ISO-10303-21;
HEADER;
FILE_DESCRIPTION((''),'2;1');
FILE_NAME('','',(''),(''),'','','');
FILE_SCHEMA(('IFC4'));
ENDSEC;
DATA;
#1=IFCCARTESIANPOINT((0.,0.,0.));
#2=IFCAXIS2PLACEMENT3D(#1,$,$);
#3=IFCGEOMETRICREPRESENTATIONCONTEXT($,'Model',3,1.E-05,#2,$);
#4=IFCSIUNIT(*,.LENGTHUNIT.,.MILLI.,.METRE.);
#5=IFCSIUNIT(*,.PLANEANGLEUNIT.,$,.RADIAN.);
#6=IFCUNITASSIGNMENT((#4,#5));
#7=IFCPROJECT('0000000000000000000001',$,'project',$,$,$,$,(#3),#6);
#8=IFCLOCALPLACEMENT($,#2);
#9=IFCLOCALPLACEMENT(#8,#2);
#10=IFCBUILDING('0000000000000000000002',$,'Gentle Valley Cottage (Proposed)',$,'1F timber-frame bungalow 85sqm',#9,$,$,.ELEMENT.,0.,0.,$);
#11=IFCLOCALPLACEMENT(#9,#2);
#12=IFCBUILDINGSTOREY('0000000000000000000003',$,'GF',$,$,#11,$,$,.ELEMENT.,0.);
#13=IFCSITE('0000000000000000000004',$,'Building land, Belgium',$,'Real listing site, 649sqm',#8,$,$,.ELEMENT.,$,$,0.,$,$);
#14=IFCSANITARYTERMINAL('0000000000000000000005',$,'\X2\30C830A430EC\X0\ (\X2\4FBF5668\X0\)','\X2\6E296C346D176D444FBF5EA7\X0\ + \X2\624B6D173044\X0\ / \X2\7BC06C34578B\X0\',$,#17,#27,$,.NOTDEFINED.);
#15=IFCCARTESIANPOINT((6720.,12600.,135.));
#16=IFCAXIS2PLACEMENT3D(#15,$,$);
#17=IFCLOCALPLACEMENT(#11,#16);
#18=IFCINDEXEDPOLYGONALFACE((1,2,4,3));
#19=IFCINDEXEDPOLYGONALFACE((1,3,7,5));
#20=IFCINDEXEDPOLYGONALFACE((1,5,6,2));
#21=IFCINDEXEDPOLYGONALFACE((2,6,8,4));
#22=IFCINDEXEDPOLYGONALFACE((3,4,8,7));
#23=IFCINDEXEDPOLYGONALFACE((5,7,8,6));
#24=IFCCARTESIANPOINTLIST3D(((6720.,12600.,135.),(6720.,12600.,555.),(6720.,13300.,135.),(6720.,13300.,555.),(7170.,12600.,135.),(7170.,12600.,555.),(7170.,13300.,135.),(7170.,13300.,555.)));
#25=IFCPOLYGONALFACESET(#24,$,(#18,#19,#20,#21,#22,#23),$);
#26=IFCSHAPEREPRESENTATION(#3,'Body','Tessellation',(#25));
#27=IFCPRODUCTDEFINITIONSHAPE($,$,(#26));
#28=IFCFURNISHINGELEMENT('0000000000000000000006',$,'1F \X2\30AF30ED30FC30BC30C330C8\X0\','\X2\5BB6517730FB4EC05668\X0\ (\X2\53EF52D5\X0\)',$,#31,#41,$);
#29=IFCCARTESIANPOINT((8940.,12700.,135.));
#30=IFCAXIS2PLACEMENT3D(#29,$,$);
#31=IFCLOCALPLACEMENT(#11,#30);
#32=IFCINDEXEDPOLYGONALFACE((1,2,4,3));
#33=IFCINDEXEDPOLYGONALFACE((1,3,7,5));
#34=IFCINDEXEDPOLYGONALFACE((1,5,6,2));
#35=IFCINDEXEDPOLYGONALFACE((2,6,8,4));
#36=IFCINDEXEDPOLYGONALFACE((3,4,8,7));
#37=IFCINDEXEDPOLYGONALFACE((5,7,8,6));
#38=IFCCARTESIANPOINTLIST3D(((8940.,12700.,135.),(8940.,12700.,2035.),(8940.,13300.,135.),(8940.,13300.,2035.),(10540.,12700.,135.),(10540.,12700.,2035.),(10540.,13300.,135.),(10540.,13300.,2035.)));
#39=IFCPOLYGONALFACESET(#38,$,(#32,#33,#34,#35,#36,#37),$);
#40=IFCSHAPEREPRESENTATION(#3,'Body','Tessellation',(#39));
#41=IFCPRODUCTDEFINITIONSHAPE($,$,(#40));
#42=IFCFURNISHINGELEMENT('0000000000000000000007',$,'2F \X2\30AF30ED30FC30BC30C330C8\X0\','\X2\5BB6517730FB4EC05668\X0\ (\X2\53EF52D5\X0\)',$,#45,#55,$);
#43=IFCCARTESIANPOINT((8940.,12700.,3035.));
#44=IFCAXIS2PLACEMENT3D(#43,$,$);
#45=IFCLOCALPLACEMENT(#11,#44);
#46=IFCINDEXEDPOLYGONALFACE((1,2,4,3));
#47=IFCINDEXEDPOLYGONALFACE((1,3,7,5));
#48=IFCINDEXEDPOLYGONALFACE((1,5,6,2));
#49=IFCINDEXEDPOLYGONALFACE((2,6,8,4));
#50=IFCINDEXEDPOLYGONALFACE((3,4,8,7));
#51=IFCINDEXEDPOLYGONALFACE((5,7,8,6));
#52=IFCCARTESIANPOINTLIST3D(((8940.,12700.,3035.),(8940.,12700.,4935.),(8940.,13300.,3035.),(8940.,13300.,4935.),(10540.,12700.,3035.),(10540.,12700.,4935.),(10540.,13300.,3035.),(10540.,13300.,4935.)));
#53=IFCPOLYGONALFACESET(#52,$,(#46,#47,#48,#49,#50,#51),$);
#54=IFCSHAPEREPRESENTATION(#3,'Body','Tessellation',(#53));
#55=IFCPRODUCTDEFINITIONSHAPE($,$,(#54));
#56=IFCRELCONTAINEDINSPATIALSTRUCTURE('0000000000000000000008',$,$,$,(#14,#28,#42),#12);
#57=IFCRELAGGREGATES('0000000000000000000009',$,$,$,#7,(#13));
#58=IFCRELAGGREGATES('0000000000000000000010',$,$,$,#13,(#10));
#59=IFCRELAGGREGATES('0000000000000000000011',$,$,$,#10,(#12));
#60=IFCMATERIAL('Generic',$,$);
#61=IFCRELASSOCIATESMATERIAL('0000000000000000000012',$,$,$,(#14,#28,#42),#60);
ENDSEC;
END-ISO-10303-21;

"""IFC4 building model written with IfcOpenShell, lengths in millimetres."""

from ifc_helpers import new_model, si_unit, frame, frame_2d, origin, place, context, project, spatial, rectangle, extrude, material, element, save


model = new_model("IFC4")

# Units and contexts
model_context = context("Model", 3, precision=1e-05, world=origin())
ifc_project = project(units=[si_unit("LENGTHUNIT", "METRE", prefix="MILLI"), si_unit("PLANEANGLEUNIT", "RADIAN")], contexts=[model_context])

# Site, building, storey
site_placement = place(None, origin())
site = spatial("IfcSite", under=ifc_project, at=site_placement, Name="Building land, Belgium", ObjectType="Real listing site, 649sqm", CompositionType="ELEMENT", RefElevation=0.0)
building_placement = place(site_placement, origin())
building = spatial("IfcBuilding", under=site, at=building_placement, Name="Gentle Valley Cottage (Proposed)", ObjectType="1F timber-frame bungalow 85sqm", CompositionType="ELEMENT", ElevationOfRefHeight=0.0, ElevationOfTerrain=0.0)
storey_placement = place(building_placement, origin())
storey = spatial("IfcBuildingStorey", under=building, at=storey_placement, Name="GF", CompositionType="ELEMENT", Elevation=0.0)

# Sanitary terminal
ifc_material_1 = material(Name="Generic")
sanitary_terminal_1_placement = place(storey_placement, frame((6720.0, 12600.0, 135.0)))
element("IfcSanitaryTerminal", 1, at=sanitary_terminal_1_placement, inside=storey, material=ifc_material_1, Name="トイレ (便器)", Description="温水洗浄便座 + 手洗い / 節水型", PredefinedType="NOTDEFINED", context=model_context, shape_type="SweptSolid", body=[
    extrude(rectangle(XDim=450.0, YDim=700.0, at=frame_2d((225.0, 350.0))), frame((6720.0, 12600.0, 135.0)), (0.0, 0.0, 1.0), 420.0),
])

# Furnishing elements
furnishing_1_placement = place(storey_placement, frame((8940.0, 12700.0, 135.0)))
element("IfcFurnishingElement", 2, at=furnishing_1_placement, inside=storey, material=ifc_material_1, Name="1F クローゼット", Description="家具・什器 (可動)", context=model_context, shape_type="SweptSolid", body=[
    extrude(rectangle(XDim=1600.0, YDim=600.0, at=frame_2d((800.0, 300.0))), frame((8940.0, 12700.0, 135.0)), (0.0, 0.0, 1.0), 1900.0),
])
furnishing_2_placement = place(storey_placement, frame((8940.0, 12700.0, 3035.0)))
element("IfcFurnishingElement", 3, at=furnishing_2_placement, inside=storey, material=ifc_material_1, Name="2F クローゼット", Description="家具・什器 (可動)", context=model_context, shape_type="SweptSolid", body=[
    extrude(rectangle(XDim=1600.0, YDim=600.0, at=frame_2d((800.0, 300.0))), frame((8940.0, 12700.0, 3035.0)), (0.0, 0.0, 1.0), 1900.0),
])

save(model, "model.ifc")
